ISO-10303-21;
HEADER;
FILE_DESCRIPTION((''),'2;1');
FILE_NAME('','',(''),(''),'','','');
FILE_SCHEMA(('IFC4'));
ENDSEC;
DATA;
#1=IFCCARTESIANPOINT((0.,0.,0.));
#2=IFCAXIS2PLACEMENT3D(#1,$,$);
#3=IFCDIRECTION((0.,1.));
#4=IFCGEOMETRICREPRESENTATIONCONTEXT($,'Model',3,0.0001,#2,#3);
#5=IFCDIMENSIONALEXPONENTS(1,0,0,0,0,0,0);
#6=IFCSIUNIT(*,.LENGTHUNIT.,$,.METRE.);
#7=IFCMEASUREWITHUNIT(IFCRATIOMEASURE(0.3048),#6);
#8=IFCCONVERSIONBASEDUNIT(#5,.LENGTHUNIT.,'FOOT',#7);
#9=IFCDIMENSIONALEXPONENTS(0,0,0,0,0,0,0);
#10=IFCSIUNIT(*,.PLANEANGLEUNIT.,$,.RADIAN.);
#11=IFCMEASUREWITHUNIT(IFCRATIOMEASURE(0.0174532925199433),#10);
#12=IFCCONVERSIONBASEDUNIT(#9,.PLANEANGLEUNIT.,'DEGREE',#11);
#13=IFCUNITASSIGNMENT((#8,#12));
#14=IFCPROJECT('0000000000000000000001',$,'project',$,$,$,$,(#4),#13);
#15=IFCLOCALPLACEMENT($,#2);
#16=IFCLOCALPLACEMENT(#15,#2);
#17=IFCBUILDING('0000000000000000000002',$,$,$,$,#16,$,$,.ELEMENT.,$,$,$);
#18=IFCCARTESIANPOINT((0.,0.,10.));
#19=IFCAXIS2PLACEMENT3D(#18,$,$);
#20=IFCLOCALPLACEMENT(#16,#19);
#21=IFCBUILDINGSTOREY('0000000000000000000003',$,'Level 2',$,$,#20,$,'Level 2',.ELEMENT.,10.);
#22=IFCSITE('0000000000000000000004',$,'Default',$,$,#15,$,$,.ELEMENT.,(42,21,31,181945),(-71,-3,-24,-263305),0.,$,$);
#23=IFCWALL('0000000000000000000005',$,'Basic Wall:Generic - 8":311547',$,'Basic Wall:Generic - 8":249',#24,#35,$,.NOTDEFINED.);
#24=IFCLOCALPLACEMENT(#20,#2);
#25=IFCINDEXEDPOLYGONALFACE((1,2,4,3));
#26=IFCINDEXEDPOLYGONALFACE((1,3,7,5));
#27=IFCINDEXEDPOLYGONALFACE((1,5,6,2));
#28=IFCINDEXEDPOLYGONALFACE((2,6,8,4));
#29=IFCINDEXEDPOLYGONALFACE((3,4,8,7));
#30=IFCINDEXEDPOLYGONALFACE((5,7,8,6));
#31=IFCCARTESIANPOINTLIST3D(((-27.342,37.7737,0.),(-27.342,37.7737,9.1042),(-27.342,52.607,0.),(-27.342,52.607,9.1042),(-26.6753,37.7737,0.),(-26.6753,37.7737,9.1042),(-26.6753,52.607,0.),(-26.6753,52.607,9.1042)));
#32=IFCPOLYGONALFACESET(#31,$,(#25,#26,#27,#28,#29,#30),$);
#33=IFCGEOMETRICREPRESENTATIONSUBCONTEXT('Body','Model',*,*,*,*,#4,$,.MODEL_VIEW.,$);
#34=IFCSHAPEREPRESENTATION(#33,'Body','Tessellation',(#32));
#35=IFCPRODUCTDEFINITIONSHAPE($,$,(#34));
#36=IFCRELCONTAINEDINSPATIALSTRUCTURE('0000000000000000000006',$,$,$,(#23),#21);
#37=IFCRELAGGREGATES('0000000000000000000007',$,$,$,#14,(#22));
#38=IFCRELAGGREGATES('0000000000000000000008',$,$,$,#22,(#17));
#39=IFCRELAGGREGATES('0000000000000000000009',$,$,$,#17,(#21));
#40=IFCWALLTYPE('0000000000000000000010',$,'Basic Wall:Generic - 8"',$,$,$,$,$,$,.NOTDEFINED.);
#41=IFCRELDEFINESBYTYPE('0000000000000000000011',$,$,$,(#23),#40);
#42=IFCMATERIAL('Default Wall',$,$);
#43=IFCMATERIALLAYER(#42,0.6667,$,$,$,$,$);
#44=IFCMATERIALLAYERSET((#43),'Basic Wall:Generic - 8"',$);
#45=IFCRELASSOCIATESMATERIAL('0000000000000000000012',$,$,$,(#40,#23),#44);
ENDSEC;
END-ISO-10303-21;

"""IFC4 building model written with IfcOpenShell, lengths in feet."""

from ifc_helpers import new_model, entity, si_unit, converted_unit, direction, frame, frame_2d, origin, place, context, subcontext, project, spatial, polyline, rectangle, extrude, clip, bounded_halfspace, material, layer, layer_set, layer_usage, type_object, element, save


model = new_model("IFC4")

# Units and contexts
model_context = context("Model", 3, precision=0.0001, world=origin(), true_north=direction((0.0, 1.0)))
body_context = subcontext(model_context, "Body", "Model", "MODEL_VIEW")
ifc_project = project(units=[converted_unit("LENGTHUNIT", "FOOT", entity("IfcRatioMeasure", 0.3048), si_unit("LENGTHUNIT", "METRE"), dimensions=[1, 0, 0, 0, 0, 0, 0]), converted_unit("PLANEANGLEUNIT", "DEGREE", entity("IfcRatioMeasure", 0.0174532925199433), si_unit("PLANEANGLEUNIT", "RADIAN"), dimensions=[0, 0, 0, 0, 0, 0, 0])], contexts=[model_context])

# Site, building, storey
site_placement = place(None, origin())
site = spatial("IfcSite", under=ifc_project, at=site_placement, Name="Default", CompositionType="ELEMENT", RefLatitude=(42, 21, 31, 181945), RefLongitude=(-71, -3, -24, -263305), RefElevation=0.0)
building_placement = place(site_placement, origin())
building = spatial("IfcBuilding", under=site, at=building_placement, CompositionType="ELEMENT")
storey_placement = place(building_placement, frame((0.0, 0.0, 10.0)))
storey = spatial("IfcBuildingStorey", under=building, at=storey_placement, Name="Level 2", LongName="Level 2", CompositionType="ELEMENT", Elevation=10.0)

# Wall
ifc_material_1 = material(Name="Default Wall")
ifc_layer = layer(ifc_material_1, 0.6667)
ifc_layer_set = layer_set([ifc_layer], Name="Basic Wall:Generic - 8\"")
ifc_layer_usage = layer_usage(ifc_layer_set, "AXIS2", "NEGATIVE", 0.3333)
wall_type = type_object("IfcWallType", Name="Basic Wall:Generic - 8\"", PredefinedType="NOTDEFINED", material=ifc_layer_set)
wall_placement = place(storey_placement, frame((-27.0087, 37.7737, 0.0), z_axis=(0.0, 0.0, 1.0), x_axis=(0.0, 1.0, 0.0)))
element("IfcWall", 1, at=wall_placement, inside=storey, type_object=wall_type, material=ifc_layer_usage, Name="Basic Wall:Generic - 8\":311547", ObjectType="Basic Wall:Generic - 8\":249", PredefinedType="NOTDEFINED", context=body_context, shape_type="Clipping", body=[
    clip(extrude(rectangle(XDim=14.8333, YDim=0.6667, at=frame_2d((7.4167, 0.0), x_axis=(-1.0, 0.0))), origin(), (0.0, 0.0, 1.0), 9.1042), bounded_halfspace(frame((0.0, -0.3333, 9.1042), z_axis=(0.0, 0.0, -1.0), x_axis=(-1.0, 0.0, 0.0)), True, frame((0.0, -0.3333, 9.1042), z_axis=(0.0, 0.0, -1.0), x_axis=(-1.0, 0.0, 0.0)), polyline([(0.0, 0.0), (0.0, 0.6667), (-14.8333, 0.6667), (-14.8333, 0.0), (0.0, 0.0)]))),
])

save(model, "model.ifc")
